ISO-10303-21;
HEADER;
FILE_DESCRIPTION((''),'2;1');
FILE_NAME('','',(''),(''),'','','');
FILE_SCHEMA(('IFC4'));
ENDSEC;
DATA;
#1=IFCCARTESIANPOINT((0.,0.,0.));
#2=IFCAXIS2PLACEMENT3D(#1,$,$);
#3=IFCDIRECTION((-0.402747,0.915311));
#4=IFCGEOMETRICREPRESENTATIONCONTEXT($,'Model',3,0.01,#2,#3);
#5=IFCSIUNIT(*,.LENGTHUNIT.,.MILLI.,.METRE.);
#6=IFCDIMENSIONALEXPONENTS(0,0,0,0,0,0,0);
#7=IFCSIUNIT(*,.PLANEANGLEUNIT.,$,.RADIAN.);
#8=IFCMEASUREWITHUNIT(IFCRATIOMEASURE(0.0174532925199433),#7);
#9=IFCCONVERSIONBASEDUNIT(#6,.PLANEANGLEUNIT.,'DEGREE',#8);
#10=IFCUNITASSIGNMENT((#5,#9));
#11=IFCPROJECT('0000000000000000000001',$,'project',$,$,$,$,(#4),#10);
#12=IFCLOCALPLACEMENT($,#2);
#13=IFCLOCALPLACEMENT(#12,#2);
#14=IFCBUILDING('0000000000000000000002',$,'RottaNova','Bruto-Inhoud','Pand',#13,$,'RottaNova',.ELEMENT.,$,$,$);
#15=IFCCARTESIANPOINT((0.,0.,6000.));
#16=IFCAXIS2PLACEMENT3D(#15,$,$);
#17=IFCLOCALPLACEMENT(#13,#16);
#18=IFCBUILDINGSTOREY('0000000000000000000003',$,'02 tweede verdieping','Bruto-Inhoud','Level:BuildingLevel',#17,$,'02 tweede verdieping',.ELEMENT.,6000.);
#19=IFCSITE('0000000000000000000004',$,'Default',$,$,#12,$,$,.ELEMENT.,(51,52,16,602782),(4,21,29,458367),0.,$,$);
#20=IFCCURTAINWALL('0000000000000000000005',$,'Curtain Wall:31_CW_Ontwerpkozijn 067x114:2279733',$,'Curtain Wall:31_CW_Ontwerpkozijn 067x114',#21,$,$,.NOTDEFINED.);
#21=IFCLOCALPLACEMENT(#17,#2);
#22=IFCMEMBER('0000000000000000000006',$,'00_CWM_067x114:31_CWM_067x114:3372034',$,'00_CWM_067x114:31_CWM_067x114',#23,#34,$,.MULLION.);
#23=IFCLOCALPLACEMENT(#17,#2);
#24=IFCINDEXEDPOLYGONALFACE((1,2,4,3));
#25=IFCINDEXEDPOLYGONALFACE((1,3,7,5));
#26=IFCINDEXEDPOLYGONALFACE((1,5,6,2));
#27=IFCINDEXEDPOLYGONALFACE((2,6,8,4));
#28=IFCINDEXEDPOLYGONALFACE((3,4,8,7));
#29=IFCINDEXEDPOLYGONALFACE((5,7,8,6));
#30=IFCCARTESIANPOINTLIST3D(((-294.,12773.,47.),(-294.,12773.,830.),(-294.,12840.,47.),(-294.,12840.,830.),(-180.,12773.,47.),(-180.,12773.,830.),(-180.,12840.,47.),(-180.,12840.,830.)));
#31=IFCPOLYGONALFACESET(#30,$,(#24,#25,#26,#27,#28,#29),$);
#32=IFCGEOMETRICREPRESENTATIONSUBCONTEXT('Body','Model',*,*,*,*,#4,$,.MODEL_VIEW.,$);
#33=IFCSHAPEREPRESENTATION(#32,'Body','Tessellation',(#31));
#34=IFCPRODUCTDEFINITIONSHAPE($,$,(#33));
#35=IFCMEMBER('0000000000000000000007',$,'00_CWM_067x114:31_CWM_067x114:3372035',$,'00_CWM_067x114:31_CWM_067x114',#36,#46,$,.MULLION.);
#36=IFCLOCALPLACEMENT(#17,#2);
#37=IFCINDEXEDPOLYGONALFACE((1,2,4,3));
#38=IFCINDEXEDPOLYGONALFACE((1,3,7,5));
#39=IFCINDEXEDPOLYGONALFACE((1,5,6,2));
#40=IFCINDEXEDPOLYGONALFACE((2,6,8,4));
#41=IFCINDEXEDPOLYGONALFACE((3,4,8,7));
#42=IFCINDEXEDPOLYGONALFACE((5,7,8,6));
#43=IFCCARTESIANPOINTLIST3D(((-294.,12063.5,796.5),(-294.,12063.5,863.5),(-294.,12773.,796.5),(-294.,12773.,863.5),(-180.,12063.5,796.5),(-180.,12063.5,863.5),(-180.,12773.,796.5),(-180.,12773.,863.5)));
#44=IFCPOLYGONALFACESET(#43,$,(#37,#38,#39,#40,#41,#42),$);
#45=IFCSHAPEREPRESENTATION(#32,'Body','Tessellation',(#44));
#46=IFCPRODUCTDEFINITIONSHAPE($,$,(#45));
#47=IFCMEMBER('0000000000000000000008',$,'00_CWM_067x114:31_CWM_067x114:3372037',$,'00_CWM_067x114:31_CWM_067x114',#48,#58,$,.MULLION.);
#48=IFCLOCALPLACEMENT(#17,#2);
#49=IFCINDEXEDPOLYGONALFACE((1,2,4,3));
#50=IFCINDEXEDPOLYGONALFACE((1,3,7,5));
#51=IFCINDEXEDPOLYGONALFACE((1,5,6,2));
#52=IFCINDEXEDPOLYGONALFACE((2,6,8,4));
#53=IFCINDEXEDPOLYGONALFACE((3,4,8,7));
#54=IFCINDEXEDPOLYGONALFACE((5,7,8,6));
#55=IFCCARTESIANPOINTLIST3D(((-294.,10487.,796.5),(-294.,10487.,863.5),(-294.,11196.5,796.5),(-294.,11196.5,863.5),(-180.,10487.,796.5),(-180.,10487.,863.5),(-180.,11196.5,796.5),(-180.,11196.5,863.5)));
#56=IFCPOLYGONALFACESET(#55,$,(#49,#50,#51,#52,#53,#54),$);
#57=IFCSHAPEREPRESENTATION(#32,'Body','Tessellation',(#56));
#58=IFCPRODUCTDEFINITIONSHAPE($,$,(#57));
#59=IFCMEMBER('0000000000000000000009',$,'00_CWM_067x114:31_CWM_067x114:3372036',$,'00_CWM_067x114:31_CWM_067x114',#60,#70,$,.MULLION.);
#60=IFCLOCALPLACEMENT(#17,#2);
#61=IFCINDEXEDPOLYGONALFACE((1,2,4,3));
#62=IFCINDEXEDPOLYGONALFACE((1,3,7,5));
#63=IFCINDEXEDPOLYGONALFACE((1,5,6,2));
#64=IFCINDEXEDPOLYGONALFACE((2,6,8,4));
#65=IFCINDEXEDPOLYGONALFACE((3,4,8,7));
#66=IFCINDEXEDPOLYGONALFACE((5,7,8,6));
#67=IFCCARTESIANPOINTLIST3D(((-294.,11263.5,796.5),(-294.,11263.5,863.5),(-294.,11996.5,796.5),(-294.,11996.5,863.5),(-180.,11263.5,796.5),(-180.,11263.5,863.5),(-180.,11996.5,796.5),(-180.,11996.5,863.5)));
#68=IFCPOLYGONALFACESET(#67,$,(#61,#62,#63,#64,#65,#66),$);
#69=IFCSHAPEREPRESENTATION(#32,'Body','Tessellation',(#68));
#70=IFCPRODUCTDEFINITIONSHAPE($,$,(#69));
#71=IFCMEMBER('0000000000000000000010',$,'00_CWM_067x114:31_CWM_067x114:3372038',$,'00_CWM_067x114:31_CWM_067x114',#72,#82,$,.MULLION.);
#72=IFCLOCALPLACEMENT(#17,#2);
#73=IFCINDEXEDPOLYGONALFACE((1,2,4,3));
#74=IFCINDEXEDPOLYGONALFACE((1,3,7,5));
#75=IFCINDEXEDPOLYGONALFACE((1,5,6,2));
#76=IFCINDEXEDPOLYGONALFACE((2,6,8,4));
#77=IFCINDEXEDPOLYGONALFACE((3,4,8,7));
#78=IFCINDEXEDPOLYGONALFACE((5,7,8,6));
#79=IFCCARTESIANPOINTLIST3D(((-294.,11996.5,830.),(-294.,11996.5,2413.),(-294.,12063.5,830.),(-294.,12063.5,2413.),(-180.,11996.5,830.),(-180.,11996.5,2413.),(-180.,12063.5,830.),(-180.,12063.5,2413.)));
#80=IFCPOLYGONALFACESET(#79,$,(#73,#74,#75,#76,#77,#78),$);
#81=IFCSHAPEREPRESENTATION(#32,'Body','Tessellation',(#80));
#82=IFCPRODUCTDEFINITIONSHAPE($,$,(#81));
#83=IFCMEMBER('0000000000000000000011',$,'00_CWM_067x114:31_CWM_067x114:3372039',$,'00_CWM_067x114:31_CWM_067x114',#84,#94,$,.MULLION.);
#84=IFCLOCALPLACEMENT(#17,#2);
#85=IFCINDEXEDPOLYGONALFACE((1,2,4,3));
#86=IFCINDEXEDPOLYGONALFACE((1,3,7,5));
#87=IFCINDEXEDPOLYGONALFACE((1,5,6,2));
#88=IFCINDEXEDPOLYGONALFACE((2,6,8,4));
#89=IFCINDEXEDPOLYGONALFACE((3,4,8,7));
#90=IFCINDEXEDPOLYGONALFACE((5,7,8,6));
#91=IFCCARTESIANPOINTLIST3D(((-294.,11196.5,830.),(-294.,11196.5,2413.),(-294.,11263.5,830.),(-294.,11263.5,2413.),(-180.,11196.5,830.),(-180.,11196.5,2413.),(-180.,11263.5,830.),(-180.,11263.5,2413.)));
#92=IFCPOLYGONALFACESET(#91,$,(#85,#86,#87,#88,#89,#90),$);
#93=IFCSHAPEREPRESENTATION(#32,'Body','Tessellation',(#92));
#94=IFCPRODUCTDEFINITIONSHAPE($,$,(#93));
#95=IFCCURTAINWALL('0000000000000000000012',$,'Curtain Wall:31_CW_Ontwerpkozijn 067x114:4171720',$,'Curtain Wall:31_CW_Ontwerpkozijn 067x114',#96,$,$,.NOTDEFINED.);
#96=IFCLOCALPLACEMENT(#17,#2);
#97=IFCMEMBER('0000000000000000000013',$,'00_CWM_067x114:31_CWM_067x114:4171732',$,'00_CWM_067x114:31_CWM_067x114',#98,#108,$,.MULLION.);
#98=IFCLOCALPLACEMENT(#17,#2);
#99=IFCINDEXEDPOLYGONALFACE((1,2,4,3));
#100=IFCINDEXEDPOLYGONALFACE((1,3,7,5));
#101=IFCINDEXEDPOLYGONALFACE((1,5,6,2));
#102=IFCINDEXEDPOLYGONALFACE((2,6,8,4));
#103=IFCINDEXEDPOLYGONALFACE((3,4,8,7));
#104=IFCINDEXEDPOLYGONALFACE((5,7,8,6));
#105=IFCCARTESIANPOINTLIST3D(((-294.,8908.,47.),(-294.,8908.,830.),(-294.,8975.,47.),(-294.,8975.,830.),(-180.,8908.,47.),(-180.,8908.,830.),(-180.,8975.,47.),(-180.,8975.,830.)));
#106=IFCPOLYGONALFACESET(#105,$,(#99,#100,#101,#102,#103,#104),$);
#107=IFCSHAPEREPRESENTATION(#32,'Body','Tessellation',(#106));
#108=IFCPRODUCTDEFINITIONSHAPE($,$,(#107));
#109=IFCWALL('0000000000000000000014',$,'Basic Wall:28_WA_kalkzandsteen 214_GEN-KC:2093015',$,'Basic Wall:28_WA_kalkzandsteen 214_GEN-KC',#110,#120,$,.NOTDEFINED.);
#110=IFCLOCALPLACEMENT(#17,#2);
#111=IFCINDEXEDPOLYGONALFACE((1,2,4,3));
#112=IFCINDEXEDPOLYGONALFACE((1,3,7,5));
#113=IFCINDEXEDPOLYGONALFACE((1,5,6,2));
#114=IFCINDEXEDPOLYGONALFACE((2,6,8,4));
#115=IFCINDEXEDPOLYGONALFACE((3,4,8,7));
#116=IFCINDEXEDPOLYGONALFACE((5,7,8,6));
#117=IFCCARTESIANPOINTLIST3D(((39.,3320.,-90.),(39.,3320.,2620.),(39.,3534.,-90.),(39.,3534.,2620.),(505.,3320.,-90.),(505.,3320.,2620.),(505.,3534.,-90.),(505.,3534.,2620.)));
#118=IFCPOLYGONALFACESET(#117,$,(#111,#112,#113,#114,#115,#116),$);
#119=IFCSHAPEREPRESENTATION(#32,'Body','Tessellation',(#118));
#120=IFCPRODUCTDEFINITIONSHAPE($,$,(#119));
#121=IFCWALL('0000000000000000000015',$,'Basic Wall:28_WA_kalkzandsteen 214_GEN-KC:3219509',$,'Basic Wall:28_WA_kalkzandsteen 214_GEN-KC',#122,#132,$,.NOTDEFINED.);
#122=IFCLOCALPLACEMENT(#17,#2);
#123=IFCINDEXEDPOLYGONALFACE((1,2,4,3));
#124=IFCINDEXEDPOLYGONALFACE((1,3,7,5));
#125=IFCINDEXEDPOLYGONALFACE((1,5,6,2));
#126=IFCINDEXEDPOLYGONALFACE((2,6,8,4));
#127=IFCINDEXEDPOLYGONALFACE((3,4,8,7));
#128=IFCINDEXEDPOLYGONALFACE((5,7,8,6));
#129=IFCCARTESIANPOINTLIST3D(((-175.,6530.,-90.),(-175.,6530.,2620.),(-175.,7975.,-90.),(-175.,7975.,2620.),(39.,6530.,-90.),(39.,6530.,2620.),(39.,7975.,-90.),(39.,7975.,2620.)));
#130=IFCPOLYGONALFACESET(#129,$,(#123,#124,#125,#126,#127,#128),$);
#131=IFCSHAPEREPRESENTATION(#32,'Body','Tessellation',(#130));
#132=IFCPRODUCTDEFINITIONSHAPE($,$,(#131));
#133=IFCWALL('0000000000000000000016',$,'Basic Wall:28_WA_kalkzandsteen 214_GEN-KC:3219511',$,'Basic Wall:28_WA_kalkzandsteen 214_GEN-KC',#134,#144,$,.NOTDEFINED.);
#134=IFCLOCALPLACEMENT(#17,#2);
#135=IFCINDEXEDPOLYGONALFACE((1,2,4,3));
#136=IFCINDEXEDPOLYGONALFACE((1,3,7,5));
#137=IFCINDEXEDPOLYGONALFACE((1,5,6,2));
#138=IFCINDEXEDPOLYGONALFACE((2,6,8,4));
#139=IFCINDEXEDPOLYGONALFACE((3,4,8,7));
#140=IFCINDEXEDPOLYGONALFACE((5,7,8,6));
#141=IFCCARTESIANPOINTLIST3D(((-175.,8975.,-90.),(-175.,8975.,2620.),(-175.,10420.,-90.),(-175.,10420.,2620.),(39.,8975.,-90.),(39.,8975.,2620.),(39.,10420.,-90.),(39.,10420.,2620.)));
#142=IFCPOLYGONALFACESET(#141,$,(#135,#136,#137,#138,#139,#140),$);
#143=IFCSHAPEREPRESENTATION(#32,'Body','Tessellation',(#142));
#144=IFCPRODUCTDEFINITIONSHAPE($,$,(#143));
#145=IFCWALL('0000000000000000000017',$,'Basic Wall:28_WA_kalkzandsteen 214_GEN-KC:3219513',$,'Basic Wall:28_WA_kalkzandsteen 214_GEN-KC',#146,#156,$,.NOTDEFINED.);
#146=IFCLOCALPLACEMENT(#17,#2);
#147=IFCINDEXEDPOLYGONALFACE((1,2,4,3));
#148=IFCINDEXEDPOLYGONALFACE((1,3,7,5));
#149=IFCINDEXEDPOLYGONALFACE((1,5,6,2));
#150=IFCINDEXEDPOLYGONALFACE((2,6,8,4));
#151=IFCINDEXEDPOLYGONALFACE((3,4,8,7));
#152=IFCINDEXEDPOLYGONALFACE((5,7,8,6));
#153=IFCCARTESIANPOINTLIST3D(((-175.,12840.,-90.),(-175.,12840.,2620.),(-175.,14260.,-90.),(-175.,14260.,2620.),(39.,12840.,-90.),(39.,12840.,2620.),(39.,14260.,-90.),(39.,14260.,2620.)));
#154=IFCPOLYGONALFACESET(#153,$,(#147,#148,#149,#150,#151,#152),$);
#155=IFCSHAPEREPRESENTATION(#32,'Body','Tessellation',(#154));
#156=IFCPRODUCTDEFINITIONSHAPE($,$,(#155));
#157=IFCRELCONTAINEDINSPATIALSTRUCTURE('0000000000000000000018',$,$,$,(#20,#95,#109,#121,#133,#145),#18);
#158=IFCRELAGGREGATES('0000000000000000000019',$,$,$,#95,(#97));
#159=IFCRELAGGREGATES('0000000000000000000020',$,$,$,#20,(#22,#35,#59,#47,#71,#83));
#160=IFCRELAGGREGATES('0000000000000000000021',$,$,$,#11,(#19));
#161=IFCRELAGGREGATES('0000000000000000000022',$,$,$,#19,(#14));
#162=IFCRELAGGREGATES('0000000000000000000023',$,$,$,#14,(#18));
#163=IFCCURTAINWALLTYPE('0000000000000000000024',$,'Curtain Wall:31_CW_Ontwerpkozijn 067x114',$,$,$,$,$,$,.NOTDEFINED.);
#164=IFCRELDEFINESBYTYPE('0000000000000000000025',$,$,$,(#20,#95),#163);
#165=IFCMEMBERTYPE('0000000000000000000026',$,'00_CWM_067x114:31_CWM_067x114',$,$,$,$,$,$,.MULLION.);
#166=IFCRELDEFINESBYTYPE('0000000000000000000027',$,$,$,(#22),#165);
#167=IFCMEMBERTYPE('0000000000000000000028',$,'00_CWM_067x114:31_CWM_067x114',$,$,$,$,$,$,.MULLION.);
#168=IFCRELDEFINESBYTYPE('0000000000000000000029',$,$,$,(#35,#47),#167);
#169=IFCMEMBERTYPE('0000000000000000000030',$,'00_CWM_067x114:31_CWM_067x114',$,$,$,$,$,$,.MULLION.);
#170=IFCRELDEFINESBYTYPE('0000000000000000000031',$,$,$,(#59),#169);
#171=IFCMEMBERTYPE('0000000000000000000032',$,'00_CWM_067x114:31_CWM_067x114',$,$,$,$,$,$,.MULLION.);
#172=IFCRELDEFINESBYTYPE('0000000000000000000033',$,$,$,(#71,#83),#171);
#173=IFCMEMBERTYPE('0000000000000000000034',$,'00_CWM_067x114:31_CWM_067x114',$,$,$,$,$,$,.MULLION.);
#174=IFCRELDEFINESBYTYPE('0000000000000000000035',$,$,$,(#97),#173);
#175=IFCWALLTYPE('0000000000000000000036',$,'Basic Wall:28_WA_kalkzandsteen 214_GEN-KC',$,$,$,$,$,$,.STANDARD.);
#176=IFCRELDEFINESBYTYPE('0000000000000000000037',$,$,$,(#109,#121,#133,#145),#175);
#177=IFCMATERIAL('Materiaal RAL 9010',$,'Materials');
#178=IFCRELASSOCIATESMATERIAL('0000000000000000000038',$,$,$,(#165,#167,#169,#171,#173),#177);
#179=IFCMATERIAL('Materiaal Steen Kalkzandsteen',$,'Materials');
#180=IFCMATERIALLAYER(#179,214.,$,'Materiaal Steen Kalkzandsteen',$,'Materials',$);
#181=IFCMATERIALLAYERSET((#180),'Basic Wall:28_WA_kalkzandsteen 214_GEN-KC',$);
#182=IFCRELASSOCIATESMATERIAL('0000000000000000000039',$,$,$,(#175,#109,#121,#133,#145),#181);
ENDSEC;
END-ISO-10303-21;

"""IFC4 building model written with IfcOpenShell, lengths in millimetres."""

from ifc_helpers import new_model, entity, si_unit, converted_unit, direction, frame, frame_2d, origin, origin_2d_with_axis, place, context, subcontext, project, spatial, rectangle, extrude, source, transform, mapped, material, layer, layer_set, material_profile, profile_set, type_object, type_shapes, element, aggregate, save


model = new_model("IFC4")

# Units and contexts
model_context = context("Model", 3, precision=0.01, world=origin(), true_north=direction((-0.402747, 0.915311)))
body_context = subcontext(model_context, "Body", "Model", "MODEL_VIEW")
ifc_project = project(units=[si_unit("LENGTHUNIT", "METRE", prefix="MILLI"), converted_unit("PLANEANGLEUNIT", "DEGREE", entity("IfcRatioMeasure", 0.0174532925199433), si_unit("PLANEANGLEUNIT", "RADIAN"), dimensions=[0, 0, 0, 0, 0, 0, 0])], contexts=[model_context])

# Site, building, storey
site_placement = place(None, origin())
site = spatial("IfcSite", under=ifc_project, at=site_placement, Name="Default", CompositionType="ELEMENT", RefLatitude=(51, 52, 16, 602782), RefLongitude=(4, 21, 29, 458367), RefElevation=0.0)
building_placement = place(site_placement, origin())
building = spatial("IfcBuilding", under=site, at=building_placement, Name="RottaNova", Description="Bruto-Inhoud", ObjectType="Pand", LongName="RottaNova", CompositionType="ELEMENT")
storey_placement = place(building_placement, frame((0.0, 0.0, 6000.0)))
storey = spatial("IfcBuildingStorey", under=building, at=storey_placement, Name="02 tweede verdieping", Description="Bruto-Inhoud", ObjectType="Level:BuildingLevel", LongName="02 tweede verdieping", CompositionType="ELEMENT", Elevation=6000.0)

# Curtain wall, members
curtain_wall_type = type_object("IfcCurtainWallType", Name="Curtain Wall:31_CW_Ontwerpkozijn 067x114", PredefinedType="NOTDEFINED")
curtain_wall_1_placement = place(storey_placement, frame((0.0, 0.0, -6000.0)))
curtain_wall_1 = element("IfcCurtainWall", 1, at=curtain_wall_1_placement, inside=storey, type_object=curtain_wall_type, Name="Curtain Wall:31_CW_Ontwerpkozijn 067x114:2279733", ObjectType="Curtain Wall:31_CW_Ontwerpkozijn 067x114", PredefinedType="NOTDEFINED")
ifc_material_1 = material(Name="Materiaal RAL 9010", Category="Materials")
ifc_material_profile = material_profile(ifc_material_1, rectangle(XDim=114.0, YDim=67.0, at=origin_2d_with_axis()), Name="31_CWM_067x114")
ifc_profile_set = profile_set([ifc_material_profile], Name="31_CWM_067x114")
member_type_1 = type_object("IfcMemberType", Name="00_CWM_067x114:31_CWM_067x114", PredefinedType="MULLION", material=ifc_profile_set)
shared_shape_1 = source(origin(), body_context, "Body", "SweptSolid", [
    extrude(rectangle(XDim=114.0, YDim=67.0, at=origin_2d_with_axis()), frame((-33.5, 57.0, -783.0), z_axis=(0.0, 0.0, 1.0), x_axis=(0.0, -1.0, 0.0)), (0.0, 0.0, 1.0), 783.0),
])
type_shapes(member_type_1, [shared_shape_1])
member_1_placement = place(curtain_wall_1_placement, frame((-180.0, 12840.0, 6830.0), z_axis=(0.0, 0.0, 1.0), x_axis=(0.0, 1.0, 0.0)))
member_1 = element("IfcMember", 2, at=member_1_placement, type_object=member_type_1, Name="00_CWM_067x114:31_CWM_067x114:3372034", ObjectType="00_CWM_067x114:31_CWM_067x114", PredefinedType="MULLION", context=body_context, shape_type="MappedRepresentation", body=[
    mapped(shared_shape_1, transform((0.0, 0.0, 0.0), scale=1.0)),
])
member_type_2 = type_object("IfcMemberType", Name="00_CWM_067x114:31_CWM_067x114", PredefinedType="MULLION", material=ifc_profile_set)
shared_shape_2 = source(origin(), body_context, "Body", "SweptSolid", [
    extrude(rectangle(XDim=114.0, YDim=67.0, at=origin_2d_with_axis()), frame((0.0, 57.0, -709.5), z_axis=(0.0, 0.0, 1.0), x_axis=(0.0, -1.0, 0.0)), (0.0, 0.0, 1.0), 709.5),
])
type_shapes(member_type_2, [shared_shape_2])
member_2_placement = place(curtain_wall_1_placement, frame((-180.0, 12063.5, 6830.0), z_axis=(0.0, -1.0, 0.0), x_axis=(0.0, 0.0, 1.0)))
member_2 = element("IfcMember", 3, at=member_2_placement, type_object=member_type_2, Name="00_CWM_067x114:31_CWM_067x114:3372035", ObjectType="00_CWM_067x114:31_CWM_067x114", PredefinedType="MULLION", context=body_context, shape_type="MappedRepresentation", body=[
    mapped(shared_shape_2, transform((0.0, 0.0, 0.0), scale=1.0)),
])
member_3_placement = place(curtain_wall_1_placement, frame((-180.0, 10487.0, 6830.0), z_axis=(0.0, -1.0, 0.0), x_axis=(0.0, 0.0, 1.0)))
member_3 = element("IfcMember", 4, at=member_3_placement, type_object=member_type_2, Name="00_CWM_067x114:31_CWM_067x114:3372037", ObjectType="00_CWM_067x114:31_CWM_067x114", PredefinedType="MULLION", context=body_context, shape_type="MappedRepresentation", body=[
    mapped(shared_shape_2, transform((0.0, 0.0, 0.0), scale=1.0)),
])
member_type_3 = type_object("IfcMemberType", Name="00_CWM_067x114:31_CWM_067x114", PredefinedType="MULLION", material=ifc_profile_set)
shared_shape_3 = source(origin(), body_context, "Body", "SweptSolid", [
    extrude(rectangle(XDim=114.0, YDim=67.0, at=origin_2d_with_axis()), frame((0.0, 57.0, -733.0), z_axis=(0.0, 0.0, 1.0), x_axis=(0.0, -1.0, 0.0)), (0.0, 0.0, 1.0), 733.0),
])
type_shapes(member_type_3, [shared_shape_3])
member_4_placement = place(curtain_wall_1_placement, frame((-180.0, 11263.5, 6830.0), z_axis=(0.0, -1.0, 0.0), x_axis=(0.0, 0.0, 1.0)))
member_4 = element("IfcMember", 5, at=member_4_placement, type_object=member_type_3, Name="00_CWM_067x114:31_CWM_067x114:3372036", ObjectType="00_CWM_067x114:31_CWM_067x114", PredefinedType="MULLION", context=body_context, shape_type="MappedRepresentation", body=[
    mapped(shared_shape_3, transform((0.0, 0.0, 0.0), scale=1.0)),
])
member_type_4 = type_object("IfcMemberType", Name="00_CWM_067x114:31_CWM_067x114", PredefinedType="MULLION", material=ifc_profile_set)
shared_shape_4 = source(origin(), body_context, "Body", "SweptSolid", [
    extrude(rectangle(XDim=114.0, YDim=67.0, at=origin_2d_with_axis()), frame((0.0, 57.0, -1583.0), z_axis=(0.0, 0.0, 1.0), x_axis=(0.0, -1.0, 0.0)), (0.0, 0.0, 1.0), 1583.0),
])
type_shapes(member_type_4, [shared_shape_4])
member_5_placement = place(curtain_wall_1_placement, frame((-180.0, 12030.0, 6830.0), z_axis=(0.0, 0.0, -1.0), x_axis=(0.0, -1.0, 0.0)))
member_5 = element("IfcMember", 6, at=member_5_placement, type_object=member_type_4, Name="00_CWM_067x114:31_CWM_067x114:3372038", ObjectType="00_CWM_067x114:31_CWM_067x114", PredefinedType="MULLION", context=body_context, shape_type="MappedRepresentation", body=[
    mapped(shared_shape_4, transform((0.0, 0.0, 0.0), scale=1.0)),
])
member_6_placement = place(curtain_wall_1_placement, frame((-180.0, 11230.0, 6830.0), z_axis=(0.0, 0.0, -1.0), x_axis=(0.0, -1.0, 0.0)))
member_6 = element("IfcMember", 7, at=member_6_placement, type_object=member_type_4, Name="00_CWM_067x114:31_CWM_067x114:3372039", ObjectType="00_CWM_067x114:31_CWM_067x114", PredefinedType="MULLION", context=body_context, shape_type="MappedRepresentation", body=[
    mapped(shared_shape_4, transform((0.0, 0.0, 0.0), scale=1.0)),
])

# Curtain wall, member
curtain_wall_2_placement = place(storey_placement, frame((0.0, 0.0, -6000.0)))
curtain_wall_2 = element("IfcCurtainWall", 8, at=curtain_wall_2_placement, inside=storey, type_object=curtain_wall_type, Name="Curtain Wall:31_CW_Ontwerpkozijn 067x114:4171720", ObjectType="Curtain Wall:31_CW_Ontwerpkozijn 067x114", PredefinedType="NOTDEFINED")
member_type_5 = type_object("IfcMemberType", Name="00_CWM_067x114:31_CWM_067x114", PredefinedType="MULLION", material=ifc_profile_set)
shared_shape_5 = source(origin(), body_context, "Body", "SweptSolid", [
    extrude(rectangle(XDim=114.0, YDim=67.0, at=origin_2d_with_axis()), frame((-33.5, 57.0, -783.0), z_axis=(0.0, 0.0, 1.0), x_axis=(0.0, -1.0, 0.0)), (0.0, 0.0, 1.0), 783.0),
])
type_shapes(member_type_5, [shared_shape_5])
member_7_placement = place(curtain_wall_2_placement, frame((-180.0, 8975.0, 6830.0), z_axis=(0.0, 0.0, 1.0), x_axis=(0.0, 1.0, 0.0)))
member_7 = element("IfcMember", 9, at=member_7_placement, type_object=member_type_5, Name="00_CWM_067x114:31_CWM_067x114:4171732", ObjectType="00_CWM_067x114:31_CWM_067x114", PredefinedType="MULLION", context=body_context, shape_type="MappedRepresentation", body=[
    mapped(shared_shape_5, transform((0.0, 0.0, 0.0), scale=1.0)),
])
aggregate(curtain_wall_2, [member_7])

# Shared definitions
ifc_material_2 = material(Name="Materiaal Steen Kalkzandsteen", Category="Materials")
ifc_layer_1 = layer(ifc_material_2, 214.0, Name="Materiaal Steen Kalkzandsteen", Category="Materials")
ifc_layer_set_1 = layer_set([ifc_layer_1], Name="Basic Wall:28_WA_kalkzandsteen 214_GEN-KC")
wall_type_1 = type_object("IfcWallType", Name="Basic Wall:28_WA_kalkzandsteen 214_GEN-KC", PredefinedType="STANDARD", material=ifc_layer_set_1)

# Walls
wall_1_placement = place(storey_placement, frame((39.0, 3427.0, -90.0)))
element("IfcWall", 10, at=wall_1_placement, inside=storey, type_object=wall_type_1, material=ifc_layer_set_1, Name="Basic Wall:28_WA_kalkzandsteen 214_GEN-KC:2093015", ObjectType="Basic Wall:28_WA_kalkzandsteen 214_GEN-KC", PredefinedType="NOTDEFINED", context=body_context, shape_type="SweptSolid", body=[
    extrude(rectangle(XDim=466.0, YDim=214.0, at=frame_2d((233.0, 0.0), x_axis=(-1.0, 0.0))), origin(), (0.0, 0.0, 1.0), 2710.0),
])
wall_2_placement = place(storey_placement, frame((-68.0, 6530.0, -90.0), z_axis=(0.0, 0.0, 1.0), x_axis=(0.0, 1.0, 0.0)))
element("IfcWall", 11, at=wall_2_placement, inside=storey, type_object=wall_type_1, material=ifc_layer_set_1, Name="Basic Wall:28_WA_kalkzandsteen 214_GEN-KC:3219509", ObjectType="Basic Wall:28_WA_kalkzandsteen 214_GEN-KC", PredefinedType="NOTDEFINED", context=body_context, shape_type="SweptSolid", body=[
    extrude(rectangle(XDim=1445.0, YDim=214.0, at=frame_2d((722.5, 0.0), x_axis=(-1.0, 0.0))), origin(), (0.0, 0.0, 1.0), 2710.0),
])
wall_3_placement = place(storey_placement, frame((-68.0, 8975.0, -90.0), z_axis=(0.0, 0.0, 1.0), x_axis=(0.0, 1.0, 0.0)))
element("IfcWall", 12, at=wall_3_placement, inside=storey, type_object=wall_type_1, material=ifc_layer_set_1, Name="Basic Wall:28_WA_kalkzandsteen 214_GEN-KC:3219511", ObjectType="Basic Wall:28_WA_kalkzandsteen 214_GEN-KC", PredefinedType="NOTDEFINED", context=body_context, shape_type="SweptSolid", body=[
    extrude(rectangle(XDim=1445.0, YDim=214.0, at=frame_2d((722.5, 0.0), x_axis=(-1.0, 0.0))), origin(), (0.0, 0.0, 1.0), 2710.0),
])
wall_4_placement = place(storey_placement, frame((-68.0, 12840.0, -90.0), z_axis=(0.0, 0.0, 1.0), x_axis=(0.0, 1.0, 0.0)))
element("IfcWall", 13, at=wall_4_placement, inside=storey, type_object=wall_type_1, material=ifc_layer_set_1, Name="Basic Wall:28_WA_kalkzandsteen 214_GEN-KC:3219513", ObjectType="Basic Wall:28_WA_kalkzandsteen 214_GEN-KC", PredefinedType="NOTDEFINED", context=body_context, shape_type="SweptSolid", body=[
    extrude(rectangle(XDim=1420.0, YDim=214.0, at=frame_2d((710.0, 0.0), x_axis=(-1.0, 0.0))), origin(), (0.0, 0.0, 1.0), 2710.0),
])

aggregate(curtain_wall_1, [member_1, member_2, member_4, member_3, member_5, member_6])

save(model, "model.ifc")
